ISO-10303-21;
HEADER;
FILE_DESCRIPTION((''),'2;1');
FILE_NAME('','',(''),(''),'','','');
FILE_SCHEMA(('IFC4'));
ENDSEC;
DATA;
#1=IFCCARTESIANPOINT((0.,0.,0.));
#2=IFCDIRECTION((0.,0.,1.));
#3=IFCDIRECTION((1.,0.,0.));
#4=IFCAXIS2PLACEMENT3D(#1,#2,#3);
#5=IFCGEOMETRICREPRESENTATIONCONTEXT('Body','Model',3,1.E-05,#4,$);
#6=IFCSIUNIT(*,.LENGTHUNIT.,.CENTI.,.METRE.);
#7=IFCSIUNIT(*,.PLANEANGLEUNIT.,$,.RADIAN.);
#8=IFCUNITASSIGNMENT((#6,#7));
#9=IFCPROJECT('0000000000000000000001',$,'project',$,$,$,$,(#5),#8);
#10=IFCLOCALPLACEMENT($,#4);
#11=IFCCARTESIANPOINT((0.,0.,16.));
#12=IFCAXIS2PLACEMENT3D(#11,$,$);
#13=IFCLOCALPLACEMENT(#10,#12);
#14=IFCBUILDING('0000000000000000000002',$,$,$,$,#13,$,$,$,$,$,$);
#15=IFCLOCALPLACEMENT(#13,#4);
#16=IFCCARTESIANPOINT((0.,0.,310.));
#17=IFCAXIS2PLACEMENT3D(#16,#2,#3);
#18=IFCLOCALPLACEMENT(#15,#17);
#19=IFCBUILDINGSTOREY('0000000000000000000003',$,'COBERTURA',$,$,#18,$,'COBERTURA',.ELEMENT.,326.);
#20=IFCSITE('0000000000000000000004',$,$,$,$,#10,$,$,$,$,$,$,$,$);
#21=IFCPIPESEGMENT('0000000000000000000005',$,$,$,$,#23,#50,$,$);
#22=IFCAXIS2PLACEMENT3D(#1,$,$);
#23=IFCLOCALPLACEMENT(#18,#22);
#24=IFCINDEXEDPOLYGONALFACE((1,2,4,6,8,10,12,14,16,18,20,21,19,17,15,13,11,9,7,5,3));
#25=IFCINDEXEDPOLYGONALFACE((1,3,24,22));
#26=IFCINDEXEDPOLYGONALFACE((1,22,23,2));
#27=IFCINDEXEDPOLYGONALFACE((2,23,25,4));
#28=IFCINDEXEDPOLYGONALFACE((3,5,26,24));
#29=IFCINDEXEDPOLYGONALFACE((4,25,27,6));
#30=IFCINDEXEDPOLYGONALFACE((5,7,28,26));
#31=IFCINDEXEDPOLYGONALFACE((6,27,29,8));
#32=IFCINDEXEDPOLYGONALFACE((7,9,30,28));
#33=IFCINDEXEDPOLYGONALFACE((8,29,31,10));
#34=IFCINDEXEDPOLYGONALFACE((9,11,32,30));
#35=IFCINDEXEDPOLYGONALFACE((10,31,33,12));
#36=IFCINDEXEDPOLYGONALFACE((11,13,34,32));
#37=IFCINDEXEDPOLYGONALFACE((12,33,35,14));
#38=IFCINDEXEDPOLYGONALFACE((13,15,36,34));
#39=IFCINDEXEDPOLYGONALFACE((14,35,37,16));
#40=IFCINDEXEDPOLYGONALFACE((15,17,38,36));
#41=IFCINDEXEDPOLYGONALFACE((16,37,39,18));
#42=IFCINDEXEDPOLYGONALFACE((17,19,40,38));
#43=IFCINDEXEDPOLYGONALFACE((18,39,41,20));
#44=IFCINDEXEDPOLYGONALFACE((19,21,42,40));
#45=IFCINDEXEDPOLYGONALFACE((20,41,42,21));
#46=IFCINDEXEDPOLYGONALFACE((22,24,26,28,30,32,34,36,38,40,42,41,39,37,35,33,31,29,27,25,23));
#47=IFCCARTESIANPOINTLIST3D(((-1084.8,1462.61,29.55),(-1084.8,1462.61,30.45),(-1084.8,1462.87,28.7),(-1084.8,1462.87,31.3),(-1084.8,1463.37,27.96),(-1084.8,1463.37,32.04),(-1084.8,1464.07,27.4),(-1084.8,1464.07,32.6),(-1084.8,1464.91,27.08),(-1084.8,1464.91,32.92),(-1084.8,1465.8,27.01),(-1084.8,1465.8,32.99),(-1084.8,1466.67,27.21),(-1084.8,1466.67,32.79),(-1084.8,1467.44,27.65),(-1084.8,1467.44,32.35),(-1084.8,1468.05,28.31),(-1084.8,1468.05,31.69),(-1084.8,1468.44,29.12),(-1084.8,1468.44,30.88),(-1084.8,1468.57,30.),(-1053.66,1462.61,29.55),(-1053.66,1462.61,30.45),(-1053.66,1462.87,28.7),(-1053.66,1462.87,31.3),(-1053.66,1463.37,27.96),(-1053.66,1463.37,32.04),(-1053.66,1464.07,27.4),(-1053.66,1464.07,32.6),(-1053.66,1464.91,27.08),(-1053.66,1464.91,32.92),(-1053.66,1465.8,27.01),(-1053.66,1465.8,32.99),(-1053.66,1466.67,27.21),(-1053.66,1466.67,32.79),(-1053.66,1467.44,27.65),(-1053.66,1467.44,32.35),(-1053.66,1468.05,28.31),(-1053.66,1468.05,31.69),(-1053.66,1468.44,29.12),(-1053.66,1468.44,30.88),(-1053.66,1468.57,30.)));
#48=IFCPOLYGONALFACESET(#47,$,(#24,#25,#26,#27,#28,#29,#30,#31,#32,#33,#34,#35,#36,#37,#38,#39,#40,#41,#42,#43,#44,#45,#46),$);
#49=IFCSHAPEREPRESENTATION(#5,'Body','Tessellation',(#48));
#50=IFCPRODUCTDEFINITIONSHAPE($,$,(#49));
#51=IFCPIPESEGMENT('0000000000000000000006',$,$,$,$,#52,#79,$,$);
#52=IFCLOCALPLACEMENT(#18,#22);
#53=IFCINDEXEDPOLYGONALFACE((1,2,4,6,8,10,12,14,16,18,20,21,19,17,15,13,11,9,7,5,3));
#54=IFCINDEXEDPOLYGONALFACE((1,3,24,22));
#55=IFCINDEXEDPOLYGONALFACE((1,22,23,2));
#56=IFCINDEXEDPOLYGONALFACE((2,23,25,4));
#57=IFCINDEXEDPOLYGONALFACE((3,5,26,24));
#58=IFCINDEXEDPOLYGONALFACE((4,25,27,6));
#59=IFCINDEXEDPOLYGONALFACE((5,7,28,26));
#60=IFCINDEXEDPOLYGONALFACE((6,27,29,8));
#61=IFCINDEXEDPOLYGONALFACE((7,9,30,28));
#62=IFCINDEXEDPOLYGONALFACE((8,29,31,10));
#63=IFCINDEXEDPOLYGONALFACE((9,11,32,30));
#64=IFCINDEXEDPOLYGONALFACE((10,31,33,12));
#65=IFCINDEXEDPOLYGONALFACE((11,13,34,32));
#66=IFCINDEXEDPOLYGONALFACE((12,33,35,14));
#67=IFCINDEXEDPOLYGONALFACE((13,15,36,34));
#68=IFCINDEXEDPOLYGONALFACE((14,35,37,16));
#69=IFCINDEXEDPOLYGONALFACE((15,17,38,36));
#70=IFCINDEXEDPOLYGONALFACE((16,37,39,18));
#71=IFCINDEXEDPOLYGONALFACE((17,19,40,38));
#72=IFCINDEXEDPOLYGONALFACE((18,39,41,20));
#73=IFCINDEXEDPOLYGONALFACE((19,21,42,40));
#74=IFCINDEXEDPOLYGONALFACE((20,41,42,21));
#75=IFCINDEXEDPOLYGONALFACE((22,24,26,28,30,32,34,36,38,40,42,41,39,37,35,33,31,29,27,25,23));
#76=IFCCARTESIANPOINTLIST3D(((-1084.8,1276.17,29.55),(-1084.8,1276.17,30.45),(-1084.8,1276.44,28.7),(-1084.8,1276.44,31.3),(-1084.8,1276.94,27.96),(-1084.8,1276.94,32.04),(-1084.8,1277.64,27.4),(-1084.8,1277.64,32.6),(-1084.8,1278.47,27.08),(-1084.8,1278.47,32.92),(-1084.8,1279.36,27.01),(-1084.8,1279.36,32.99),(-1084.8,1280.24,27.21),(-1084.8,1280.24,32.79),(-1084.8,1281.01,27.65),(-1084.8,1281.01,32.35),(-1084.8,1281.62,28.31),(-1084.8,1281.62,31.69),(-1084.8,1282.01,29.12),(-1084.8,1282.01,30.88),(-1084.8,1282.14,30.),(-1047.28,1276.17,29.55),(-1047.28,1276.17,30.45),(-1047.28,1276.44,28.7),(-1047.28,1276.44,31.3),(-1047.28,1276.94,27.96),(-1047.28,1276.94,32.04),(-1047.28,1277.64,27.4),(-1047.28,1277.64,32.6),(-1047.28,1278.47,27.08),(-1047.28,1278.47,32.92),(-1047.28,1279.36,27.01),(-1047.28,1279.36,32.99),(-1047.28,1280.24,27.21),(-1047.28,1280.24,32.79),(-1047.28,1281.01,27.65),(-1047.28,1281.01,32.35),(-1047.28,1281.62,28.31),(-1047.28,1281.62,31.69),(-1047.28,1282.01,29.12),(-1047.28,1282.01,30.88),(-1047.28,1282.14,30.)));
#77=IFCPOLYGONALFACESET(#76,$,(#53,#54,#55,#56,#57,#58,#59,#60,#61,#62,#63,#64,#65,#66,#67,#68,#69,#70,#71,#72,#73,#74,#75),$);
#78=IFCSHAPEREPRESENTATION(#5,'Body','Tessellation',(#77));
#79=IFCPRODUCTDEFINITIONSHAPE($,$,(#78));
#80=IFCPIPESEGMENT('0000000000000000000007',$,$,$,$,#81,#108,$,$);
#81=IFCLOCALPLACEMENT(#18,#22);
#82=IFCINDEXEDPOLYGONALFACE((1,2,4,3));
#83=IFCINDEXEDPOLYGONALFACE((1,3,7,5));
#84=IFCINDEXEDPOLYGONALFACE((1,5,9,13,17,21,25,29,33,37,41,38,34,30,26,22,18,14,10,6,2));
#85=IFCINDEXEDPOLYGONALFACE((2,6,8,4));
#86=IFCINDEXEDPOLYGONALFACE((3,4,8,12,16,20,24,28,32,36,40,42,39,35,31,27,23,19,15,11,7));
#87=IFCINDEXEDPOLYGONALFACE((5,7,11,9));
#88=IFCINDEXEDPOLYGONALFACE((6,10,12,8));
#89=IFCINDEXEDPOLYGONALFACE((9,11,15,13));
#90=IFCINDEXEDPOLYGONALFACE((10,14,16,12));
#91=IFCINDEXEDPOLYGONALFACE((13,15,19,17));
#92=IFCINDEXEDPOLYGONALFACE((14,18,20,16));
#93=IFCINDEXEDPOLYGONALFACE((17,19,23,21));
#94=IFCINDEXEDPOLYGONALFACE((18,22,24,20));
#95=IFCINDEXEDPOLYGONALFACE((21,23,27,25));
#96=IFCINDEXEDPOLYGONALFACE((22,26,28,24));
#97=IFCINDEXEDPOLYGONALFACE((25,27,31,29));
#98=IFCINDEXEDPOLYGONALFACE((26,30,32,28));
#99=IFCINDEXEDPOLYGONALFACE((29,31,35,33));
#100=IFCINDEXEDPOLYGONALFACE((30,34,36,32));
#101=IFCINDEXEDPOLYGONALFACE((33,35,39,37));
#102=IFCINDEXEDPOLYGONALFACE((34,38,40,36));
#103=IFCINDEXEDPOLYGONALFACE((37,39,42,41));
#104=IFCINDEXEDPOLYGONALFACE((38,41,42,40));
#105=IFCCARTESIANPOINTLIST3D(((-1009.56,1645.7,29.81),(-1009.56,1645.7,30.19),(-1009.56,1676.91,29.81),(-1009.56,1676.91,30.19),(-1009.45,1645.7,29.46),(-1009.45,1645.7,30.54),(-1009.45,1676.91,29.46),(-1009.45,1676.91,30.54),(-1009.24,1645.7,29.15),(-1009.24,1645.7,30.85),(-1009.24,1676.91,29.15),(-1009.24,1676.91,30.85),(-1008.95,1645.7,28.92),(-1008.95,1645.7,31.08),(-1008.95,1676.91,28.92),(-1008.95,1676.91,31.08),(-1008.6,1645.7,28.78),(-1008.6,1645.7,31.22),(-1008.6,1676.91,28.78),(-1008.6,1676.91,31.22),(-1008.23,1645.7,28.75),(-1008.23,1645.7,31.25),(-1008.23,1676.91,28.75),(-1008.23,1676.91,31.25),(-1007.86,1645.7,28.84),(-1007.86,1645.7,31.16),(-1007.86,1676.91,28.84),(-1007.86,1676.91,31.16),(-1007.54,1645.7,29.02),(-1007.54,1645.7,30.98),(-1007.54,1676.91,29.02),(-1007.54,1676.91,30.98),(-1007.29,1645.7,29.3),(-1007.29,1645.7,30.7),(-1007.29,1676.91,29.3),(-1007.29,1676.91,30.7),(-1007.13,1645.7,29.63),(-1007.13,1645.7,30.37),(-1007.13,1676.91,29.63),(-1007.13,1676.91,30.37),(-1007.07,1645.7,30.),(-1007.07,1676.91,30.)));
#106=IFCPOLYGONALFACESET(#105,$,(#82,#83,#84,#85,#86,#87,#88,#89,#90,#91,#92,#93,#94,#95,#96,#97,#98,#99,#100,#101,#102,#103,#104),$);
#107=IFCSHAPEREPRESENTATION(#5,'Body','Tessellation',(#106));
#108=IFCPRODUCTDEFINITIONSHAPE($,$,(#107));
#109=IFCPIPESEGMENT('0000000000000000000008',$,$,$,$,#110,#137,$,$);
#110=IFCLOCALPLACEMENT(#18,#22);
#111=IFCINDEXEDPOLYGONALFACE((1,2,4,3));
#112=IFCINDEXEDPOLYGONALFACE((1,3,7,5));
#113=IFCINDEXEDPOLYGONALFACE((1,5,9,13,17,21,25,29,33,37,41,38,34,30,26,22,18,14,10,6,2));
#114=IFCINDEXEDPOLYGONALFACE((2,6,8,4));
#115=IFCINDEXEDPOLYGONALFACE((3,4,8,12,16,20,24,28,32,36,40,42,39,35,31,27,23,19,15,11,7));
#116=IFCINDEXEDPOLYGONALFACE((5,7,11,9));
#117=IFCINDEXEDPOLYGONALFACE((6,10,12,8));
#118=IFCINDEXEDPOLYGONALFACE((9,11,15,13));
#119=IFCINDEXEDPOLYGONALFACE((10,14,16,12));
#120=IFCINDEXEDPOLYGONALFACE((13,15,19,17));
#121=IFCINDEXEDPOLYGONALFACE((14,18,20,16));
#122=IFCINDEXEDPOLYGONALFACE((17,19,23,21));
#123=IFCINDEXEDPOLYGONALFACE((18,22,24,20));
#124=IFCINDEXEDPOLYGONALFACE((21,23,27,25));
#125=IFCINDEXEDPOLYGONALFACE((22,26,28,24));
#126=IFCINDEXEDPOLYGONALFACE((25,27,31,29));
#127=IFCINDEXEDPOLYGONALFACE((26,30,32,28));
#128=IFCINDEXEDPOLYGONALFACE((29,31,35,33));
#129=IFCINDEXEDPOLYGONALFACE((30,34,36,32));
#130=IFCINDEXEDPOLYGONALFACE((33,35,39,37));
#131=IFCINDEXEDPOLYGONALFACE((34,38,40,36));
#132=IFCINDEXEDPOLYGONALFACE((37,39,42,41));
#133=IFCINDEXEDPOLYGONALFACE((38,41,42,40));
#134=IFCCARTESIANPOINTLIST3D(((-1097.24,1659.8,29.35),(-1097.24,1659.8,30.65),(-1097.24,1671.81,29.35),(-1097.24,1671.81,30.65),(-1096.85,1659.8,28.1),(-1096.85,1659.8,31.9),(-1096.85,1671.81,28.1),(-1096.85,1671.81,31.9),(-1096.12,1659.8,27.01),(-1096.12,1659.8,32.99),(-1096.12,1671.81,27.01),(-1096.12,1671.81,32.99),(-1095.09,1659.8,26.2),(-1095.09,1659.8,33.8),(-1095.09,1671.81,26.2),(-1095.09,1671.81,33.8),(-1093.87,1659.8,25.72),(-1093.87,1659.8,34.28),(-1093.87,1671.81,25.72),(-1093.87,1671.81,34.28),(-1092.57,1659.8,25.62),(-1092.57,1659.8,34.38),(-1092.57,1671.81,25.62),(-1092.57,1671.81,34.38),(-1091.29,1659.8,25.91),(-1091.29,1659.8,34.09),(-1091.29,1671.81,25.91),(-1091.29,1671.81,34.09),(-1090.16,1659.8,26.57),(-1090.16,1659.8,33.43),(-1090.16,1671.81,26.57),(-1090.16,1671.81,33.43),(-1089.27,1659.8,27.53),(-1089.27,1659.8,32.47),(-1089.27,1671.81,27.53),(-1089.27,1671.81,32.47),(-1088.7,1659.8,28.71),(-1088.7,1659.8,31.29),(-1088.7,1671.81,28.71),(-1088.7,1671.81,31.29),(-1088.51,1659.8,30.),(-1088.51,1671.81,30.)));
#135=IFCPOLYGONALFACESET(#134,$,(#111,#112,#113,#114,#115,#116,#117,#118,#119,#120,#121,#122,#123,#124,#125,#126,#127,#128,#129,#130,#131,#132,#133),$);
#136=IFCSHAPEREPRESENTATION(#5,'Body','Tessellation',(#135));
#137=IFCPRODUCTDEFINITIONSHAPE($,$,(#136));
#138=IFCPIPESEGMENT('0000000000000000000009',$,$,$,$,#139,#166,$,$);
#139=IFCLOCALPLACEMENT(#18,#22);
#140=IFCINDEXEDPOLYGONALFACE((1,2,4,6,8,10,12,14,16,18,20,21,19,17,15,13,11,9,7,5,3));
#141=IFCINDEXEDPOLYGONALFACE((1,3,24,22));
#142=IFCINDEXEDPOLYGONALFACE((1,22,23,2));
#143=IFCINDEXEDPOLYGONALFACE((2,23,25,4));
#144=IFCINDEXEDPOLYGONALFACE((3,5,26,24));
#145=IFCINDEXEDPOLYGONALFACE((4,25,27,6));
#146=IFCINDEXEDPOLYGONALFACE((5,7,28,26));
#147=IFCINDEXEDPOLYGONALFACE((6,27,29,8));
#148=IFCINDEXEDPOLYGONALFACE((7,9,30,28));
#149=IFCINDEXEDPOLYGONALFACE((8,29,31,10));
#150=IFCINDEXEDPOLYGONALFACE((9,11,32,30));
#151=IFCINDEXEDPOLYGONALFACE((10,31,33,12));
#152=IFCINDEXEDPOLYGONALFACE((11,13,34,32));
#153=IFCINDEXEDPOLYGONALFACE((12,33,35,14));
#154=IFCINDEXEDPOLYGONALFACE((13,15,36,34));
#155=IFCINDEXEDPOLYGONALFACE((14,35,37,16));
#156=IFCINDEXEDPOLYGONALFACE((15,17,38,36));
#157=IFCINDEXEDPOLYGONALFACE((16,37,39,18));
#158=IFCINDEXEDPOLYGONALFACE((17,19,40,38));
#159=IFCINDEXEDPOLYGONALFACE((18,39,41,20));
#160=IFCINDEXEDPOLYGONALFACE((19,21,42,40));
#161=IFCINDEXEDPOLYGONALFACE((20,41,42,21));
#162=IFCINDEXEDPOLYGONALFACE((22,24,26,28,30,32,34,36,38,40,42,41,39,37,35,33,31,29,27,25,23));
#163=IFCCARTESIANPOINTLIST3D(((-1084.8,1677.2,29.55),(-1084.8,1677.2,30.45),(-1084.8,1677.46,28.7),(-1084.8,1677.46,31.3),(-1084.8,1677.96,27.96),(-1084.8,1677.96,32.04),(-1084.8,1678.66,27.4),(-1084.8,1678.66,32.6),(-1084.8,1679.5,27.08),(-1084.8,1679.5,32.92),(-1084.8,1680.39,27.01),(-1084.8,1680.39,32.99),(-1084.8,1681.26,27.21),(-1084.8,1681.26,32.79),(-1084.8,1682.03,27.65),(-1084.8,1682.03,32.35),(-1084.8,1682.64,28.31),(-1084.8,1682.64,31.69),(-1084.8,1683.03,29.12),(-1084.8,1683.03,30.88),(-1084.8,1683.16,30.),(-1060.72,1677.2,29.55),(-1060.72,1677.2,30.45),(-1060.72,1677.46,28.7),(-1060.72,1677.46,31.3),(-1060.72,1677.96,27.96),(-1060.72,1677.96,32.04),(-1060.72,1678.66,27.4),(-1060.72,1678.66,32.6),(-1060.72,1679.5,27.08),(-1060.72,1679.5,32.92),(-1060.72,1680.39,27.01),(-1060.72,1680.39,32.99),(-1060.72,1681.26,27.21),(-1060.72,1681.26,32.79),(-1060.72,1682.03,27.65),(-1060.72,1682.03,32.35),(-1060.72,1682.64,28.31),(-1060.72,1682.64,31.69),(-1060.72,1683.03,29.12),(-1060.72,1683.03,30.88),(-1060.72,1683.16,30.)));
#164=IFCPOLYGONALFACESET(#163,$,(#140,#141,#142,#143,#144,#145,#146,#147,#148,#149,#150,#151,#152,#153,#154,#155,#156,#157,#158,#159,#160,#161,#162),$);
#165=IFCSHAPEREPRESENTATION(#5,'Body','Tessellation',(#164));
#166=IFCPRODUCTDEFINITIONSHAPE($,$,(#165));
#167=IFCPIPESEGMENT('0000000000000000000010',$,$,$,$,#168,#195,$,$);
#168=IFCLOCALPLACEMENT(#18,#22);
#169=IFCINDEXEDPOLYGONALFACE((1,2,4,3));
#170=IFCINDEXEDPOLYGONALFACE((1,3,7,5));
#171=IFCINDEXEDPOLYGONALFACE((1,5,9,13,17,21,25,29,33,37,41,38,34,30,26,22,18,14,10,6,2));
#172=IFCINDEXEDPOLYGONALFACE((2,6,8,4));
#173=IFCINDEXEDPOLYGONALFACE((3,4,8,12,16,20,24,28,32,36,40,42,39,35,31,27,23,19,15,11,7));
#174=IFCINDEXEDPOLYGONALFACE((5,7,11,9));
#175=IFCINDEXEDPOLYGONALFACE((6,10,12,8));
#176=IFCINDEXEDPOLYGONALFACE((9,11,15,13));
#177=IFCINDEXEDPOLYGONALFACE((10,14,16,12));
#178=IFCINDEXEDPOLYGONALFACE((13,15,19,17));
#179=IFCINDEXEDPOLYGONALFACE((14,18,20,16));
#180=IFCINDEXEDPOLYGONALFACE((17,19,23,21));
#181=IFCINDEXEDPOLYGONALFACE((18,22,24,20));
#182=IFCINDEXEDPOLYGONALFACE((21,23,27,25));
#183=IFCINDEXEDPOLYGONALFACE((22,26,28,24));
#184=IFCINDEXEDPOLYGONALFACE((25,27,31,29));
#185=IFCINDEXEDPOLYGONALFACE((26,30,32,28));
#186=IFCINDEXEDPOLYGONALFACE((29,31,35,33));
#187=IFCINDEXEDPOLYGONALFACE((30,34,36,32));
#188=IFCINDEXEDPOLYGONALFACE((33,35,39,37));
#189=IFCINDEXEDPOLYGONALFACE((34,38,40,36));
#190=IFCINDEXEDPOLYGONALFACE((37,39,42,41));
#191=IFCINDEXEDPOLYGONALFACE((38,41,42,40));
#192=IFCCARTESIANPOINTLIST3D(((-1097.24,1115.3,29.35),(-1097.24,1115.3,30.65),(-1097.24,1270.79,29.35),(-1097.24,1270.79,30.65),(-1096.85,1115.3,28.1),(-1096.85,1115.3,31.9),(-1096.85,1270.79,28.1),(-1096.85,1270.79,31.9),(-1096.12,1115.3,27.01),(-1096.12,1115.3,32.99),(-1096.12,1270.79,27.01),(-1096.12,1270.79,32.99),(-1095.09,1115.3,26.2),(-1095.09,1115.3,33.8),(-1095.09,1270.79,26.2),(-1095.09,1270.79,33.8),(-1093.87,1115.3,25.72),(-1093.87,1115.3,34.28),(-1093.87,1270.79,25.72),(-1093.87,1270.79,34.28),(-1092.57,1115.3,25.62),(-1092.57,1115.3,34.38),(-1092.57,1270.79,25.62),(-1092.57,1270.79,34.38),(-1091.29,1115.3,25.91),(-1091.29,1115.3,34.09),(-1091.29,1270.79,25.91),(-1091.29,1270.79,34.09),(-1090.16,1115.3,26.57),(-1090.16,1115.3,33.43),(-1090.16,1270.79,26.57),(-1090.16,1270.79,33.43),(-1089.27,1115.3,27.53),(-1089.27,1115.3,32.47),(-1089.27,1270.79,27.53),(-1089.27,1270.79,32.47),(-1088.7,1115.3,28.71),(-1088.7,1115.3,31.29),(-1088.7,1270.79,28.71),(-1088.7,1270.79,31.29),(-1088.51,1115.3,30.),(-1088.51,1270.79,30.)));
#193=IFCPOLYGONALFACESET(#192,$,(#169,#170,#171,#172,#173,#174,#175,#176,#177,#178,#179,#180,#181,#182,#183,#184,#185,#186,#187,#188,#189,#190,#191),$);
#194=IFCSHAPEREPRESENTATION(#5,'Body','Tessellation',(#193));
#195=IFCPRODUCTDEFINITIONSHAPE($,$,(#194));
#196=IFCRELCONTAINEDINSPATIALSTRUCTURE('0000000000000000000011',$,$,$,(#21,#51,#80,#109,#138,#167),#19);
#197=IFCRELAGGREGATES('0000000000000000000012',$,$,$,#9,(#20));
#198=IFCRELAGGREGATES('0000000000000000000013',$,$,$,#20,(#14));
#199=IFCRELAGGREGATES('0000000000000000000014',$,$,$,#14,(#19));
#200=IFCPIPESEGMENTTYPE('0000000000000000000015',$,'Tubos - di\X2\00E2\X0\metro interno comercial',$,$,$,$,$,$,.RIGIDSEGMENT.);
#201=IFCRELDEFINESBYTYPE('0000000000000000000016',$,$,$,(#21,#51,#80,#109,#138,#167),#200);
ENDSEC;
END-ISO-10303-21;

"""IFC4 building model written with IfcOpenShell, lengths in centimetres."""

from ifc_helpers import new_model, si_unit, frame, origin_with_axes, origin_2d_with_axis, place, context, project, spatial, circle, extrude, type_object, element, save


model = new_model("IFC4")

# Units and contexts
model_context = context("Model", 3, precision=1e-05, world=origin_with_axes(), identifier="Body")
ifc_project = project(units=[si_unit("LENGTHUNIT", "METRE", prefix="CENTI"), si_unit("PLANEANGLEUNIT", "RADIAN")], contexts=[model_context])

# Site, building, storey
site_placement = place(None, origin_with_axes())
site = spatial("IfcSite", under=ifc_project, at=site_placement)
building_placement = place(site_placement, frame((0.0, 0.0, 16.0)))
building = spatial("IfcBuilding", under=site, at=building_placement)
placement = place(building_placement, origin_with_axes())
storey_placement = place(placement, frame((0.0, 0.0, 310.0), z_axis=(0.0, 0.0, 1.0), x_axis=(1.0, 0.0, 0.0)))
storey = spatial("IfcBuildingStorey", under=building, at=storey_placement, Name="COBERTURA", LongName="COBERTURA", CompositionType="ELEMENT", Elevation=326.0)

# Pipe segments
pipe_segment_type = type_object("IfcPipeSegmentType", Name="Tubos - diâmetro interno comercial", PredefinedType="RIGIDSEGMENT")
pipe_segment_1_placement = place(storey_placement, frame((-1069.23, 1465.57, 33.0), z_axis=(0.0, 0.0, 1.0), x_axis=(1.0, 0.0, 0.0)))
element("IfcPipeSegment", 1, at=pipe_segment_1_placement, inside=storey, type_object=pipe_segment_type, context=model_context, shape_type="SolidModel", body=[
    extrude(circle(Radius=3.0, at=origin_2d_with_axis()), frame((-15.57, 0.0, -3.0), z_axis=(1.0, 0.0, 0.0), x_axis=(0.0, 1.0, 0.0)), (0.0, 0.0, 1.0), 31.14),
])
pipe_segment_2_placement = place(storey_placement, frame((-1066.04, 1279.14, 33.0), z_axis=(0.0, 0.0, 1.0), x_axis=(1.0, 0.0, 0.0)))
element("IfcPipeSegment", 2, at=pipe_segment_2_placement, inside=storey, type_object=pipe_segment_type, context=model_context, shape_type="SolidModel", body=[
    extrude(circle(Radius=3.0, at=origin_2d_with_axis()), frame((-18.76, 0.0, -3.0), z_axis=(1.0, 0.0, 0.0), x_axis=(0.0, 1.0, 0.0)), (0.0, 0.0, 1.0), 37.51),
])
pipe_segment_3_placement = place(storey_placement, frame((-1008.32, 1661.3, 31.25), z_axis=(0.0, 0.0, 1.0), x_axis=(1.0, 0.0, 0.0)))
element("IfcPipeSegment", 3, at=pipe_segment_3_placement, inside=storey, type_object=pipe_segment_type, context=model_context, shape_type="SolidModel", body=[
    extrude(circle(Radius=1.25, at=origin_2d_with_axis()), frame((0.0, 15.61, -1.25), z_axis=(0.0, -1.0, 0.0), x_axis=(1.0, 0.0, 0.0)), (0.0, 0.0, 1.0), 31.22),
])
pipe_segment_4_placement = place(storey_placement, frame((-1092.9, 1665.8, 34.39), z_axis=(0.0, 0.0, 1.0), x_axis=(1.0, 0.0, 0.0)))
element("IfcPipeSegment", 4, at=pipe_segment_4_placement, inside=storey, type_object=pipe_segment_type, context=model_context, shape_type="SolidModel", body=[
    extrude(circle(Radius=4.39, at=origin_2d_with_axis()), frame((0.0, 6.01, -4.39), z_axis=(0.0, -1.0, 0.0), x_axis=(1.0, 0.0, 0.0)), (0.0, 0.0, 1.0), 12.02),
])
pipe_segment_5_placement = place(storey_placement, frame((-1072.76, 1680.16, 33.0), z_axis=(0.0, 0.0, 1.0), x_axis=(1.0, 0.0, 0.0)))
element("IfcPipeSegment", 5, at=pipe_segment_5_placement, inside=storey, type_object=pipe_segment_type, context=model_context, shape_type="SolidModel", body=[
    extrude(circle(Radius=3.0, at=origin_2d_with_axis()), frame((-12.04, 0.0, -3.0), z_axis=(1.0, 0.0, 0.0), x_axis=(0.0, 1.0, 0.0)), (0.0, 0.0, 1.0), 24.08),
])
pipe_segment_6_placement = place(storey_placement, frame((-1092.9, 1193.05, 34.39), z_axis=(0.0, 0.0, 1.0), x_axis=(1.0, 0.0, 0.0)))
element("IfcPipeSegment", 6, at=pipe_segment_6_placement, inside=storey, type_object=pipe_segment_type, context=model_context, shape_type="SolidModel", body=[
    extrude(circle(Radius=4.39, at=origin_2d_with_axis()), frame((0.0, 77.74, -4.39), z_axis=(0.0, -1.0, 0.0), x_axis=(1.0, 0.0, 0.0)), (0.0, 0.0, 1.0), 155.49),
])

save(model, "model.ifc")
